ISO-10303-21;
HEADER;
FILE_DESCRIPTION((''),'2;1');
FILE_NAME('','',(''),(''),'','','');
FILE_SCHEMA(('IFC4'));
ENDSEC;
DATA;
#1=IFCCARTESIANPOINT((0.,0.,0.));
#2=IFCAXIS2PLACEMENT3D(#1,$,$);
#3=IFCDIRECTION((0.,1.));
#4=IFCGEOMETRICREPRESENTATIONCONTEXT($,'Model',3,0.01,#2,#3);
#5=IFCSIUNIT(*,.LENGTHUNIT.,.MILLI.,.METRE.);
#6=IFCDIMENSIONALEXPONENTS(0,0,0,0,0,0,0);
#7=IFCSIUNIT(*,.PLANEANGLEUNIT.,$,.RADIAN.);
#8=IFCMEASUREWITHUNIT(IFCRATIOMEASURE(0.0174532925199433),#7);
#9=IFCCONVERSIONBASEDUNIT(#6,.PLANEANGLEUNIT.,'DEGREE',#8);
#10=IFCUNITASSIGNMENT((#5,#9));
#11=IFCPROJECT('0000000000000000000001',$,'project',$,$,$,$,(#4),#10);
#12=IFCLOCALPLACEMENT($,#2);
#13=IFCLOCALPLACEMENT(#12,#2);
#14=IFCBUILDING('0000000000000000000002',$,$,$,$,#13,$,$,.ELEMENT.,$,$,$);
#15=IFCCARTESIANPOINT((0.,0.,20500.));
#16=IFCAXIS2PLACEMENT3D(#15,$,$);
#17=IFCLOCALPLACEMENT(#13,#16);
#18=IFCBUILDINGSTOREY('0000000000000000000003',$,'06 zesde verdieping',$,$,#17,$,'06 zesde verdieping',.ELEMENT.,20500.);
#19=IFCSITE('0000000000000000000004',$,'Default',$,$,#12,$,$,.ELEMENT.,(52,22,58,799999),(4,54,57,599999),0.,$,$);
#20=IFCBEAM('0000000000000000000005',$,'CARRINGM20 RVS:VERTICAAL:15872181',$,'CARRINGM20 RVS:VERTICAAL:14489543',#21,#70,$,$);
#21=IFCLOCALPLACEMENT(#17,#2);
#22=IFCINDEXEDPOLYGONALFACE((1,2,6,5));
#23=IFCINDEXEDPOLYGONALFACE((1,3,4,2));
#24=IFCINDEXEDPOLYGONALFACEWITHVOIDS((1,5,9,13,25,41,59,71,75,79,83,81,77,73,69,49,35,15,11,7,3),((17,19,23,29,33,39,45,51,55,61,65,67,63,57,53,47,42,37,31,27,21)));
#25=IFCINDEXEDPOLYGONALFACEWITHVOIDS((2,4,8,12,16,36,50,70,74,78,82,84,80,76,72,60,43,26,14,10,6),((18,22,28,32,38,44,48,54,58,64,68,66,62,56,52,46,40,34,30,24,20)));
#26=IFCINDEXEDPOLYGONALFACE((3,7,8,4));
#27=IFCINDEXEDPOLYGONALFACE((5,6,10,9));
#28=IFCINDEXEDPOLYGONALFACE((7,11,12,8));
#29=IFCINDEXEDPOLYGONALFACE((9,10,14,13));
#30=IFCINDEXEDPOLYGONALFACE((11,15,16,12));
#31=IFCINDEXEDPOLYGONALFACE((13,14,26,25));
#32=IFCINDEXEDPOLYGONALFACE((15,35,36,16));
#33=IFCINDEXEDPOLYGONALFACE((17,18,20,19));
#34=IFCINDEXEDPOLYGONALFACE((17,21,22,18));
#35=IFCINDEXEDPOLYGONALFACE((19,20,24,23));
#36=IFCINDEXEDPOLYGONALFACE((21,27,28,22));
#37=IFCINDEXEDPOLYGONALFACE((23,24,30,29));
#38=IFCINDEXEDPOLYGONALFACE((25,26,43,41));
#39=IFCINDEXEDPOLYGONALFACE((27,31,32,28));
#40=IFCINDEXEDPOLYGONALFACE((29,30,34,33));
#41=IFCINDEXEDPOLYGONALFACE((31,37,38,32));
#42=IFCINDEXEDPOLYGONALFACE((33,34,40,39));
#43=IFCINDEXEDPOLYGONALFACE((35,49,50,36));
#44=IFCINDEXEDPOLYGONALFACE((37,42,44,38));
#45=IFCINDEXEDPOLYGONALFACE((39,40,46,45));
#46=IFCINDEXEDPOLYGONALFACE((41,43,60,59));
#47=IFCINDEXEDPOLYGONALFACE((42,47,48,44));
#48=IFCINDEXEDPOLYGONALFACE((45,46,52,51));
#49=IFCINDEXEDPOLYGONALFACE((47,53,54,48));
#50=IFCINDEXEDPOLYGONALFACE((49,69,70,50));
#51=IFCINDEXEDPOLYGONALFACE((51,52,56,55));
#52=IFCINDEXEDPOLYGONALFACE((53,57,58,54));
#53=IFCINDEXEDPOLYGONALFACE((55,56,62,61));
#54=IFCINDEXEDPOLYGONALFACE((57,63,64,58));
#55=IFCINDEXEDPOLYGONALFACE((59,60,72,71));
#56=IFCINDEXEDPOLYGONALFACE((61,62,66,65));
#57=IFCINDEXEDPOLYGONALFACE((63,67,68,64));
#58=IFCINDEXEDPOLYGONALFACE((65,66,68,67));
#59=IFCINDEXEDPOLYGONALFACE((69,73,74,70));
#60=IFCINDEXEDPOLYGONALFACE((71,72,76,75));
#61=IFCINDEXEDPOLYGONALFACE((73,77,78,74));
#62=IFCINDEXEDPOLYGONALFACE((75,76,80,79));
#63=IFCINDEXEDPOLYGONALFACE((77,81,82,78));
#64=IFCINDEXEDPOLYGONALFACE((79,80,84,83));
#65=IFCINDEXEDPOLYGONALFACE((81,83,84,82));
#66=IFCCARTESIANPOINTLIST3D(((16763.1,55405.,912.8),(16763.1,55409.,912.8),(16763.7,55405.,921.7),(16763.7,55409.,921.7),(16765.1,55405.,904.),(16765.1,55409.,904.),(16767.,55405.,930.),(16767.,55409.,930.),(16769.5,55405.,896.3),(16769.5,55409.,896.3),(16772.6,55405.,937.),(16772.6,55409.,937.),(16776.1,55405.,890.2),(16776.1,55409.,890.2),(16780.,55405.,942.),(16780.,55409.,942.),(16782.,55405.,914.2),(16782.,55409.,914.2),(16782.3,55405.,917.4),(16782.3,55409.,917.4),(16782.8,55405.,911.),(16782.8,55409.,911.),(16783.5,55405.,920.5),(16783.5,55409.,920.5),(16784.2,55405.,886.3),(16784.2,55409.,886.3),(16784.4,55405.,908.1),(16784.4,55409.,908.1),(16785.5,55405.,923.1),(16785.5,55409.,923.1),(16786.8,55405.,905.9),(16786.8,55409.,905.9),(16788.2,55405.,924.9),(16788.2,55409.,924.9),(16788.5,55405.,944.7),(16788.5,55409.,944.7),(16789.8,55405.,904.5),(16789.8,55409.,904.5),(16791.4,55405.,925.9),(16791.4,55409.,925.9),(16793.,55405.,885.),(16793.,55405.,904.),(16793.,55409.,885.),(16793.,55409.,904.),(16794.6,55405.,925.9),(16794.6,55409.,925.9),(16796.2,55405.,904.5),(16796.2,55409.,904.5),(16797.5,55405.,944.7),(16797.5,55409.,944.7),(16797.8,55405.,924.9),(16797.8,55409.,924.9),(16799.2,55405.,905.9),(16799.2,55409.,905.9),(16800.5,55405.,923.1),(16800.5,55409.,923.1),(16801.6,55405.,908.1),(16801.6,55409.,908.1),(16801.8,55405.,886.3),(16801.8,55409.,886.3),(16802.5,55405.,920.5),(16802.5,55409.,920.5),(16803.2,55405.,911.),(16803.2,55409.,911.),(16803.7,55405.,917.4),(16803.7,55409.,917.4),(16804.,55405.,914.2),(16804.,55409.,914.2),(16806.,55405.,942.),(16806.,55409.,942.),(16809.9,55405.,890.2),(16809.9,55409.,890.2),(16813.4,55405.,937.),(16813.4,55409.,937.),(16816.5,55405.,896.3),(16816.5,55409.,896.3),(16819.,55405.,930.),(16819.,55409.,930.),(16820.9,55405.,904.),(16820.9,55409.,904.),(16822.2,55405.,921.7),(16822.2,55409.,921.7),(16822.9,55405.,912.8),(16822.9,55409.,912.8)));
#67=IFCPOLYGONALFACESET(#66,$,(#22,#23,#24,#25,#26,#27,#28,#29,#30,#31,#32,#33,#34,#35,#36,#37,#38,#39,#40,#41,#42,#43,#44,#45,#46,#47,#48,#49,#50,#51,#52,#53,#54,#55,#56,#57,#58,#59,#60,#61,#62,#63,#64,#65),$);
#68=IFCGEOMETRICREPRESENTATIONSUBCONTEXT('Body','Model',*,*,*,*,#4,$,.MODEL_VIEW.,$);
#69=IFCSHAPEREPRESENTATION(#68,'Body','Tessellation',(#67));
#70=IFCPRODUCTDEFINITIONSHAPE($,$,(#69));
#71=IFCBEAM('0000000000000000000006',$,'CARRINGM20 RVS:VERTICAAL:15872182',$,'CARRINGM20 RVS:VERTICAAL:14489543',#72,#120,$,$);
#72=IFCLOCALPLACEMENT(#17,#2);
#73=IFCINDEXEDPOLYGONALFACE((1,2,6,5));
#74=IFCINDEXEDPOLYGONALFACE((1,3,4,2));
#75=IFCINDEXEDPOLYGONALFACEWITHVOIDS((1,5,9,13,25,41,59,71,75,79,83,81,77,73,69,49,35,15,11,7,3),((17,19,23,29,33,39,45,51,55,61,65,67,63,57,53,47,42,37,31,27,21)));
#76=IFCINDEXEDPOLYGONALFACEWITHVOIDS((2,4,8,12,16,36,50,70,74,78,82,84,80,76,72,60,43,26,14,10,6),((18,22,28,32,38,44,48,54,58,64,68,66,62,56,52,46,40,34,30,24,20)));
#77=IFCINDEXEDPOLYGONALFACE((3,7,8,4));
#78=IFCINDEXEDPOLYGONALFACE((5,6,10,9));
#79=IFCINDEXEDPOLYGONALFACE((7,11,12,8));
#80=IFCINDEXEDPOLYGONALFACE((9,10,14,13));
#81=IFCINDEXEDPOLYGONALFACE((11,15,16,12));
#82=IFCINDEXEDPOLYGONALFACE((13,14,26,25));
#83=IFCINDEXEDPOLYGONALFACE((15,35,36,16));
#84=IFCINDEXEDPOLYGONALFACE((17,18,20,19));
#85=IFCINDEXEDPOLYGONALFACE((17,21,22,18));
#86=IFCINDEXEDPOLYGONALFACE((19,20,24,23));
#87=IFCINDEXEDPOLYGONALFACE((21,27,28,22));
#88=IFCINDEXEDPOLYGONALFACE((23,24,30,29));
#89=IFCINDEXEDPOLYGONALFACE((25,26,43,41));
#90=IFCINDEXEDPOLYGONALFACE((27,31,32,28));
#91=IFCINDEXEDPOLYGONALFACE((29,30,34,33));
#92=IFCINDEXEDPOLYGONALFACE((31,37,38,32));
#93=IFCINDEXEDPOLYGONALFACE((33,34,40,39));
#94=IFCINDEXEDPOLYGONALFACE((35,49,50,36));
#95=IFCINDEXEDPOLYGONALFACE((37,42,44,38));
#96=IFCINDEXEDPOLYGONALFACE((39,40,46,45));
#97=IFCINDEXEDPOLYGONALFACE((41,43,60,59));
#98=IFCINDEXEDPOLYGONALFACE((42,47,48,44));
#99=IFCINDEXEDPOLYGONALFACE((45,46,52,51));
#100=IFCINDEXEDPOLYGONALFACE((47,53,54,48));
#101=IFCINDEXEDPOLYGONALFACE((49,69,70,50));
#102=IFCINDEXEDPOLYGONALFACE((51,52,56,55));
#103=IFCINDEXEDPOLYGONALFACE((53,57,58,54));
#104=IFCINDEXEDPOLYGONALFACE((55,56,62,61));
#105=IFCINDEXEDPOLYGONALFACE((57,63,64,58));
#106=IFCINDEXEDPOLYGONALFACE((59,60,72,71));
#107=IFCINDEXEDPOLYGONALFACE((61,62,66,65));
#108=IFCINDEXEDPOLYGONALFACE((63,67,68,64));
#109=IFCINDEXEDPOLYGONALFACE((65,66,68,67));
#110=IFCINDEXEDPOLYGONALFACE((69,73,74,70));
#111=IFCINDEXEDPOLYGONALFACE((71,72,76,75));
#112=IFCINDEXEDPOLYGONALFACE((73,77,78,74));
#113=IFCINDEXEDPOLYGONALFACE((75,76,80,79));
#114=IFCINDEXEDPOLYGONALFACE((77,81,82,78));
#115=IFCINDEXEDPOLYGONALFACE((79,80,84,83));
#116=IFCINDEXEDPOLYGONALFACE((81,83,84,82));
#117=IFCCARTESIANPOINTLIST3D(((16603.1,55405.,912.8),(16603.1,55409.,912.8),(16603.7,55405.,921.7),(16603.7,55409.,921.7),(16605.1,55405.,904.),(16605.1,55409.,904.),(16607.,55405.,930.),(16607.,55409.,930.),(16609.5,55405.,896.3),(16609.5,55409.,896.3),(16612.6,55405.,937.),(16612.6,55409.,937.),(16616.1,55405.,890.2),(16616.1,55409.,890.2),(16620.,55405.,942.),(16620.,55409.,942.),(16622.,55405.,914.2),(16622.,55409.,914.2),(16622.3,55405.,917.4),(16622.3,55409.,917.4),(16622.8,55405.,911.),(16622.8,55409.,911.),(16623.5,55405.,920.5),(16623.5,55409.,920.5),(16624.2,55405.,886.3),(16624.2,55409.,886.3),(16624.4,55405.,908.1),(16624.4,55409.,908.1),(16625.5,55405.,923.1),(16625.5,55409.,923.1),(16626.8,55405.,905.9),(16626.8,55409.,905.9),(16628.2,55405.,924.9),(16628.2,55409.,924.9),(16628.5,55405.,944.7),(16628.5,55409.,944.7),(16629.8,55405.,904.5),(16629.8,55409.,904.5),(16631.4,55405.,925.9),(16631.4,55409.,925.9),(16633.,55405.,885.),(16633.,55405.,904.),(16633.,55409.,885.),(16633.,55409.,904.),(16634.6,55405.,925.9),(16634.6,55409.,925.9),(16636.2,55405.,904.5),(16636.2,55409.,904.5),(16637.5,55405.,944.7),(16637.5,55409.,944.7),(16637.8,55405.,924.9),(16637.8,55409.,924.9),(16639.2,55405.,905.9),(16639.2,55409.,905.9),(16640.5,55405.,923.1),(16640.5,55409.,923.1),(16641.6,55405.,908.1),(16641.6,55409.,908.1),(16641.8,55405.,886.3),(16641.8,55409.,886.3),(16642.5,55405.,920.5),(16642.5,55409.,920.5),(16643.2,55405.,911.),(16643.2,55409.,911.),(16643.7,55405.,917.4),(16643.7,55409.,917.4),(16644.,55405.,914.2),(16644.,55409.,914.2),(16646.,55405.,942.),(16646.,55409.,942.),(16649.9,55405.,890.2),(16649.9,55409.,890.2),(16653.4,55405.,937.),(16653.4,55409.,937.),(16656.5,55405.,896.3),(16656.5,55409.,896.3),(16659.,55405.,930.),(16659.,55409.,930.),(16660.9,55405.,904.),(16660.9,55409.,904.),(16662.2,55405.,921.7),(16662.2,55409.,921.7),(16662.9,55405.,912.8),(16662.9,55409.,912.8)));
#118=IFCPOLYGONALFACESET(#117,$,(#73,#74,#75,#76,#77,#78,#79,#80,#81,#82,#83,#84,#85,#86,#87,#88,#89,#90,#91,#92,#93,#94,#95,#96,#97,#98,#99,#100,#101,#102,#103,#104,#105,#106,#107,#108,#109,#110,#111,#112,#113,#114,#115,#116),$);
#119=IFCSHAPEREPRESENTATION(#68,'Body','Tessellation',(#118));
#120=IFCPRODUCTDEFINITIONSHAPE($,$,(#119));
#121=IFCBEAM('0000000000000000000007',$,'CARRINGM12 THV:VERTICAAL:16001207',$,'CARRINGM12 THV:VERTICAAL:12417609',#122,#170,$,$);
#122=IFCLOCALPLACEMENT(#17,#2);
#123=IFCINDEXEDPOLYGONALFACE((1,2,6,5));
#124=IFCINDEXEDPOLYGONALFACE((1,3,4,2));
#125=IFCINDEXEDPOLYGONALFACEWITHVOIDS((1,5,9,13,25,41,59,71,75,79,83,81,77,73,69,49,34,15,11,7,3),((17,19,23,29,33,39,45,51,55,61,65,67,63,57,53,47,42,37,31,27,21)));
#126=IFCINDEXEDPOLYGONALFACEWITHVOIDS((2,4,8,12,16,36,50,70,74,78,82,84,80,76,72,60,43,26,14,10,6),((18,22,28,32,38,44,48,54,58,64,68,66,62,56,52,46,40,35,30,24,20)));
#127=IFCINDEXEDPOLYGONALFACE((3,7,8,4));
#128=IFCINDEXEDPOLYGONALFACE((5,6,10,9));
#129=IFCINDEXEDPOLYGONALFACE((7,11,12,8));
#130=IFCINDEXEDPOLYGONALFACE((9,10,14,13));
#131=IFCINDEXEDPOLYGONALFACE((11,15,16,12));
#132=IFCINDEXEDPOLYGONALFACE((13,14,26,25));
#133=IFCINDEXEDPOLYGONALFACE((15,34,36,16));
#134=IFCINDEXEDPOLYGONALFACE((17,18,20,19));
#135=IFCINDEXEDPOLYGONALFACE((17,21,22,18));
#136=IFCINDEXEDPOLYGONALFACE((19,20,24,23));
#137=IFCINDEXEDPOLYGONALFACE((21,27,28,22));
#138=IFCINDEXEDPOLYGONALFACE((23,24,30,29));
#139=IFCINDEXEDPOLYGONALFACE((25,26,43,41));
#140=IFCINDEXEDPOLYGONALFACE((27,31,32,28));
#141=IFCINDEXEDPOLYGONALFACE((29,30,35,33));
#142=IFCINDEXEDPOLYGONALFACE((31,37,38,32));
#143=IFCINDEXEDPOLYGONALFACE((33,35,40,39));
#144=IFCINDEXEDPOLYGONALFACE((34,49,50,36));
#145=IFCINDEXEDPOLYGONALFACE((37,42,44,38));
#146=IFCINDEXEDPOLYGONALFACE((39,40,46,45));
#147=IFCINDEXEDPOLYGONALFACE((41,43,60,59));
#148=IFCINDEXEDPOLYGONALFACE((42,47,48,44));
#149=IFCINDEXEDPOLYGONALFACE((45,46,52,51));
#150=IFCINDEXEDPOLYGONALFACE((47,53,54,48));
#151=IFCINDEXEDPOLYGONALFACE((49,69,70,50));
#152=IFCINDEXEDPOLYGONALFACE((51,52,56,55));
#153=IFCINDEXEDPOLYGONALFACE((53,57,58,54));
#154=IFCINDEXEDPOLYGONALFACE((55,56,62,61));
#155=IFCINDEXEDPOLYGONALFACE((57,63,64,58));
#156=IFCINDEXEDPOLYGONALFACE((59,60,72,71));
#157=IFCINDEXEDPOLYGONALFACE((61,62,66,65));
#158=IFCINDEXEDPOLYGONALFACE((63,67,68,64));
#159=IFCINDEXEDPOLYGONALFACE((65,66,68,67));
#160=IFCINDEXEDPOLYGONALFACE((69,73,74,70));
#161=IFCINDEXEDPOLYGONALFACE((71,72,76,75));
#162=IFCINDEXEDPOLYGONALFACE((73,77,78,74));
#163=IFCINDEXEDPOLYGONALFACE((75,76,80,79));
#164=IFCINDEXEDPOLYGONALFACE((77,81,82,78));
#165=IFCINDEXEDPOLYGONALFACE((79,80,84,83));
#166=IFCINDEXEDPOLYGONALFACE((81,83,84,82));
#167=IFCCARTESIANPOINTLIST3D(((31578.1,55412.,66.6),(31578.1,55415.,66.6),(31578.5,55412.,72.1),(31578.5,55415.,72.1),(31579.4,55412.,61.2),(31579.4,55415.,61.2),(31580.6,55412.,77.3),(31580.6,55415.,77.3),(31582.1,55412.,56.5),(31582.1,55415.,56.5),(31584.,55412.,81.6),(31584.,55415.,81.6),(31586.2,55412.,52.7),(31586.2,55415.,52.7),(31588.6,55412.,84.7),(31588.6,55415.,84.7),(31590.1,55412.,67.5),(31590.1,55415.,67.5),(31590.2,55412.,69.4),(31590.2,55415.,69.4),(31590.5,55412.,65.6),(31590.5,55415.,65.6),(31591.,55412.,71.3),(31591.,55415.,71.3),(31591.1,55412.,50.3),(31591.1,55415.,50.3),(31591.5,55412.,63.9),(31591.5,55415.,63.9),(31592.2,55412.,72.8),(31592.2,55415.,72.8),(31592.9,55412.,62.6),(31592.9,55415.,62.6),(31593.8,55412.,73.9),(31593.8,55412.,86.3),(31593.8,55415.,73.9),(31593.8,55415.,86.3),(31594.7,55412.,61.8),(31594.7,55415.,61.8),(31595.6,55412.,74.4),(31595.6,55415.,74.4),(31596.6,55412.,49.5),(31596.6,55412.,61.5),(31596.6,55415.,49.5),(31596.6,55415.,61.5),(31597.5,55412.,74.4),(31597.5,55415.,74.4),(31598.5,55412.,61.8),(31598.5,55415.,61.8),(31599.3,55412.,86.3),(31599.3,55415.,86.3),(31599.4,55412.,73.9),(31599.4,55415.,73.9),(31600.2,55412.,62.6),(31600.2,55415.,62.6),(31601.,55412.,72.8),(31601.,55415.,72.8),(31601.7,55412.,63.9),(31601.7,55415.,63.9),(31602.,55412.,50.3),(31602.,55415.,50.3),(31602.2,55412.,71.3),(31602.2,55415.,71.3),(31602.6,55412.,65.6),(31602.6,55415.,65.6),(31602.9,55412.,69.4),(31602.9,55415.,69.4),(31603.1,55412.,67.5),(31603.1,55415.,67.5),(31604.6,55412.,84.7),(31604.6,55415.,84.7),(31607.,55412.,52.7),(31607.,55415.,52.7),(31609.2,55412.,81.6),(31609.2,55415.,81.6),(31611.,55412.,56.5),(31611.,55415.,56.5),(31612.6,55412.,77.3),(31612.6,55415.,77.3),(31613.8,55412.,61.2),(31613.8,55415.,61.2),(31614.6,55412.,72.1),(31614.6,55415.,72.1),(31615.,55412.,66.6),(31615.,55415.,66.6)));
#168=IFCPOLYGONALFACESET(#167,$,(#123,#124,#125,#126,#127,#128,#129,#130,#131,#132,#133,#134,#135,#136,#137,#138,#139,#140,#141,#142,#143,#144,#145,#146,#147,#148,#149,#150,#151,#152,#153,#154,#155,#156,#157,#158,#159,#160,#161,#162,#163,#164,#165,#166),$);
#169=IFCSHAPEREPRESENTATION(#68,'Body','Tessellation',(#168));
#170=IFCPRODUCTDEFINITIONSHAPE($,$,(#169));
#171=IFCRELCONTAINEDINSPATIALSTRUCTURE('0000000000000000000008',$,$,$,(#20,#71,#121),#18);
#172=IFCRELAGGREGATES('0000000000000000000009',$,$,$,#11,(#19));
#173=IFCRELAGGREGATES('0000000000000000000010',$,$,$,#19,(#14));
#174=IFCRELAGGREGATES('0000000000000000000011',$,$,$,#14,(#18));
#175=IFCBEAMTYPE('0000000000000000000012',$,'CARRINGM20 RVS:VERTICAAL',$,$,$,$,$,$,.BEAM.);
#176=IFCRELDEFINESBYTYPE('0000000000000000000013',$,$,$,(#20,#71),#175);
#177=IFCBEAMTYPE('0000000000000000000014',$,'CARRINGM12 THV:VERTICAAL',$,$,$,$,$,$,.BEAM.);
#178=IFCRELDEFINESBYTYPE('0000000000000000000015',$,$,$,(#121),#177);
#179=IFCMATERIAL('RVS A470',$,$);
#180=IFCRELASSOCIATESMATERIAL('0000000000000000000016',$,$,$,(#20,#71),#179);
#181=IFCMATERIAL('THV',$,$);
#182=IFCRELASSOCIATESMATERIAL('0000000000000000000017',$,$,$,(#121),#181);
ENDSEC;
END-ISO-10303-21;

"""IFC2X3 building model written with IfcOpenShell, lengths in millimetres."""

from ifc_helpers import new_model, entity, si_unit, converted_unit, direction, frame, origin, origin_2d_with_axis, place, context, subcontext, project, spatial, hollow_circle, extrude, material, type_object, element, save


model = new_model("IFC2X3")

# Units and contexts
model_context = context("Model", 3, precision=0.01, world=origin(), true_north=direction((0.0, 1.0)))
body_context = subcontext(model_context, "Body", "Model", "MODEL_VIEW")
ifc_project = project(units=[si_unit("LENGTHUNIT", "METRE", prefix="MILLI"), converted_unit("PLANEANGLEUNIT", "DEGREE", entity("IfcRatioMeasure", 0.0174532925199433), si_unit("PLANEANGLEUNIT", "RADIAN"), dimensions=[0, 0, 0, 0, 0, 0, 0])], contexts=[model_context])

# Site, building, storey
site_placement = place(None, origin())
site = spatial("IfcSite", under=ifc_project, at=site_placement, Name="Default", CompositionType="ELEMENT", RefLatitude=(52, 22, 58, 799999), RefLongitude=(4, 54, 57, 599999), RefElevation=0.0)
building_placement = place(site_placement, origin())
building = spatial("IfcBuilding", under=site, at=building_placement, CompositionType="ELEMENT")
storey_placement = place(building_placement, frame((0.0, 0.0, 20500.0)))
storey = spatial("IfcBuildingStorey", under=building, at=storey_placement, Name="06 zesde verdieping", LongName="06 zesde verdieping", CompositionType="ELEMENT", Elevation=20500.0)

# Beams
ifc_material_1 = material(Name="RVS A470")
beam_type_1 = type_object("IfcBeamType", Name="CARRINGM20 RVS:VERTICAAL", PredefinedType="BEAM")
beam_1_placement = place(storey_placement, origin())
element("IfcBeam", 1, at=beam_1_placement, inside=storey, type_object=beam_type_1, material=ifc_material_1, Name="CARRINGM20 RVS:VERTICAAL:15872181", ObjectType="CARRINGM20 RVS:VERTICAAL:14489543", context=body_context, shape_type="SweptSolid", body=[
    extrude(hollow_circle(Radius=30.0, WallThickness=19.0, at=origin_2d_with_axis()), frame((16793.0, 55405.0, 915.0), z_axis=(0.0, 1.0, 0.0), x_axis=(0.0, 0.0, -1.0)), (0.0, 0.0, 1.0), 4.0),
])
beam_2_placement = place(storey_placement, origin())
element("IfcBeam", 2, at=beam_2_placement, inside=storey, type_object=beam_type_1, material=ifc_material_1, Name="CARRINGM20 RVS:VERTICAAL:15872182", ObjectType="CARRINGM20 RVS:VERTICAAL:14489543", context=body_context, shape_type="SweptSolid", body=[
    extrude(hollow_circle(Radius=30.0, WallThickness=19.0, at=origin_2d_with_axis()), frame((16633.0, 55405.0, 915.0), z_axis=(0.0, 1.0, 0.0), x_axis=(0.0, 0.0, -1.0)), (0.0, 0.0, 1.0), 4.0),
])
ifc_material_2 = material(Name="THV")
beam_type_2 = type_object("IfcBeamType", Name="CARRINGM12 THV:VERTICAAL", PredefinedType="BEAM")
beam_3_placement = place(storey_placement, origin())
element("IfcBeam", 3, at=beam_3_placement, inside=storey, type_object=beam_type_2, material=ifc_material_2, Name="CARRINGM12 THV:VERTICAAL:16001207", ObjectType="CARRINGM12 THV:VERTICAAL:12417609", context=body_context, shape_type="SweptSolid", body=[
    extrude(hollow_circle(Radius=18.5, WallThickness=12.0, at=origin_2d_with_axis()), frame((31596.6, 55412.0, 68.0), z_axis=(0.0, 1.0, 0.0), x_axis=(0.0, 0.0, -1.0)), (0.0, 0.0, 1.0), 3.0),
])

save(model, "model.ifc")
